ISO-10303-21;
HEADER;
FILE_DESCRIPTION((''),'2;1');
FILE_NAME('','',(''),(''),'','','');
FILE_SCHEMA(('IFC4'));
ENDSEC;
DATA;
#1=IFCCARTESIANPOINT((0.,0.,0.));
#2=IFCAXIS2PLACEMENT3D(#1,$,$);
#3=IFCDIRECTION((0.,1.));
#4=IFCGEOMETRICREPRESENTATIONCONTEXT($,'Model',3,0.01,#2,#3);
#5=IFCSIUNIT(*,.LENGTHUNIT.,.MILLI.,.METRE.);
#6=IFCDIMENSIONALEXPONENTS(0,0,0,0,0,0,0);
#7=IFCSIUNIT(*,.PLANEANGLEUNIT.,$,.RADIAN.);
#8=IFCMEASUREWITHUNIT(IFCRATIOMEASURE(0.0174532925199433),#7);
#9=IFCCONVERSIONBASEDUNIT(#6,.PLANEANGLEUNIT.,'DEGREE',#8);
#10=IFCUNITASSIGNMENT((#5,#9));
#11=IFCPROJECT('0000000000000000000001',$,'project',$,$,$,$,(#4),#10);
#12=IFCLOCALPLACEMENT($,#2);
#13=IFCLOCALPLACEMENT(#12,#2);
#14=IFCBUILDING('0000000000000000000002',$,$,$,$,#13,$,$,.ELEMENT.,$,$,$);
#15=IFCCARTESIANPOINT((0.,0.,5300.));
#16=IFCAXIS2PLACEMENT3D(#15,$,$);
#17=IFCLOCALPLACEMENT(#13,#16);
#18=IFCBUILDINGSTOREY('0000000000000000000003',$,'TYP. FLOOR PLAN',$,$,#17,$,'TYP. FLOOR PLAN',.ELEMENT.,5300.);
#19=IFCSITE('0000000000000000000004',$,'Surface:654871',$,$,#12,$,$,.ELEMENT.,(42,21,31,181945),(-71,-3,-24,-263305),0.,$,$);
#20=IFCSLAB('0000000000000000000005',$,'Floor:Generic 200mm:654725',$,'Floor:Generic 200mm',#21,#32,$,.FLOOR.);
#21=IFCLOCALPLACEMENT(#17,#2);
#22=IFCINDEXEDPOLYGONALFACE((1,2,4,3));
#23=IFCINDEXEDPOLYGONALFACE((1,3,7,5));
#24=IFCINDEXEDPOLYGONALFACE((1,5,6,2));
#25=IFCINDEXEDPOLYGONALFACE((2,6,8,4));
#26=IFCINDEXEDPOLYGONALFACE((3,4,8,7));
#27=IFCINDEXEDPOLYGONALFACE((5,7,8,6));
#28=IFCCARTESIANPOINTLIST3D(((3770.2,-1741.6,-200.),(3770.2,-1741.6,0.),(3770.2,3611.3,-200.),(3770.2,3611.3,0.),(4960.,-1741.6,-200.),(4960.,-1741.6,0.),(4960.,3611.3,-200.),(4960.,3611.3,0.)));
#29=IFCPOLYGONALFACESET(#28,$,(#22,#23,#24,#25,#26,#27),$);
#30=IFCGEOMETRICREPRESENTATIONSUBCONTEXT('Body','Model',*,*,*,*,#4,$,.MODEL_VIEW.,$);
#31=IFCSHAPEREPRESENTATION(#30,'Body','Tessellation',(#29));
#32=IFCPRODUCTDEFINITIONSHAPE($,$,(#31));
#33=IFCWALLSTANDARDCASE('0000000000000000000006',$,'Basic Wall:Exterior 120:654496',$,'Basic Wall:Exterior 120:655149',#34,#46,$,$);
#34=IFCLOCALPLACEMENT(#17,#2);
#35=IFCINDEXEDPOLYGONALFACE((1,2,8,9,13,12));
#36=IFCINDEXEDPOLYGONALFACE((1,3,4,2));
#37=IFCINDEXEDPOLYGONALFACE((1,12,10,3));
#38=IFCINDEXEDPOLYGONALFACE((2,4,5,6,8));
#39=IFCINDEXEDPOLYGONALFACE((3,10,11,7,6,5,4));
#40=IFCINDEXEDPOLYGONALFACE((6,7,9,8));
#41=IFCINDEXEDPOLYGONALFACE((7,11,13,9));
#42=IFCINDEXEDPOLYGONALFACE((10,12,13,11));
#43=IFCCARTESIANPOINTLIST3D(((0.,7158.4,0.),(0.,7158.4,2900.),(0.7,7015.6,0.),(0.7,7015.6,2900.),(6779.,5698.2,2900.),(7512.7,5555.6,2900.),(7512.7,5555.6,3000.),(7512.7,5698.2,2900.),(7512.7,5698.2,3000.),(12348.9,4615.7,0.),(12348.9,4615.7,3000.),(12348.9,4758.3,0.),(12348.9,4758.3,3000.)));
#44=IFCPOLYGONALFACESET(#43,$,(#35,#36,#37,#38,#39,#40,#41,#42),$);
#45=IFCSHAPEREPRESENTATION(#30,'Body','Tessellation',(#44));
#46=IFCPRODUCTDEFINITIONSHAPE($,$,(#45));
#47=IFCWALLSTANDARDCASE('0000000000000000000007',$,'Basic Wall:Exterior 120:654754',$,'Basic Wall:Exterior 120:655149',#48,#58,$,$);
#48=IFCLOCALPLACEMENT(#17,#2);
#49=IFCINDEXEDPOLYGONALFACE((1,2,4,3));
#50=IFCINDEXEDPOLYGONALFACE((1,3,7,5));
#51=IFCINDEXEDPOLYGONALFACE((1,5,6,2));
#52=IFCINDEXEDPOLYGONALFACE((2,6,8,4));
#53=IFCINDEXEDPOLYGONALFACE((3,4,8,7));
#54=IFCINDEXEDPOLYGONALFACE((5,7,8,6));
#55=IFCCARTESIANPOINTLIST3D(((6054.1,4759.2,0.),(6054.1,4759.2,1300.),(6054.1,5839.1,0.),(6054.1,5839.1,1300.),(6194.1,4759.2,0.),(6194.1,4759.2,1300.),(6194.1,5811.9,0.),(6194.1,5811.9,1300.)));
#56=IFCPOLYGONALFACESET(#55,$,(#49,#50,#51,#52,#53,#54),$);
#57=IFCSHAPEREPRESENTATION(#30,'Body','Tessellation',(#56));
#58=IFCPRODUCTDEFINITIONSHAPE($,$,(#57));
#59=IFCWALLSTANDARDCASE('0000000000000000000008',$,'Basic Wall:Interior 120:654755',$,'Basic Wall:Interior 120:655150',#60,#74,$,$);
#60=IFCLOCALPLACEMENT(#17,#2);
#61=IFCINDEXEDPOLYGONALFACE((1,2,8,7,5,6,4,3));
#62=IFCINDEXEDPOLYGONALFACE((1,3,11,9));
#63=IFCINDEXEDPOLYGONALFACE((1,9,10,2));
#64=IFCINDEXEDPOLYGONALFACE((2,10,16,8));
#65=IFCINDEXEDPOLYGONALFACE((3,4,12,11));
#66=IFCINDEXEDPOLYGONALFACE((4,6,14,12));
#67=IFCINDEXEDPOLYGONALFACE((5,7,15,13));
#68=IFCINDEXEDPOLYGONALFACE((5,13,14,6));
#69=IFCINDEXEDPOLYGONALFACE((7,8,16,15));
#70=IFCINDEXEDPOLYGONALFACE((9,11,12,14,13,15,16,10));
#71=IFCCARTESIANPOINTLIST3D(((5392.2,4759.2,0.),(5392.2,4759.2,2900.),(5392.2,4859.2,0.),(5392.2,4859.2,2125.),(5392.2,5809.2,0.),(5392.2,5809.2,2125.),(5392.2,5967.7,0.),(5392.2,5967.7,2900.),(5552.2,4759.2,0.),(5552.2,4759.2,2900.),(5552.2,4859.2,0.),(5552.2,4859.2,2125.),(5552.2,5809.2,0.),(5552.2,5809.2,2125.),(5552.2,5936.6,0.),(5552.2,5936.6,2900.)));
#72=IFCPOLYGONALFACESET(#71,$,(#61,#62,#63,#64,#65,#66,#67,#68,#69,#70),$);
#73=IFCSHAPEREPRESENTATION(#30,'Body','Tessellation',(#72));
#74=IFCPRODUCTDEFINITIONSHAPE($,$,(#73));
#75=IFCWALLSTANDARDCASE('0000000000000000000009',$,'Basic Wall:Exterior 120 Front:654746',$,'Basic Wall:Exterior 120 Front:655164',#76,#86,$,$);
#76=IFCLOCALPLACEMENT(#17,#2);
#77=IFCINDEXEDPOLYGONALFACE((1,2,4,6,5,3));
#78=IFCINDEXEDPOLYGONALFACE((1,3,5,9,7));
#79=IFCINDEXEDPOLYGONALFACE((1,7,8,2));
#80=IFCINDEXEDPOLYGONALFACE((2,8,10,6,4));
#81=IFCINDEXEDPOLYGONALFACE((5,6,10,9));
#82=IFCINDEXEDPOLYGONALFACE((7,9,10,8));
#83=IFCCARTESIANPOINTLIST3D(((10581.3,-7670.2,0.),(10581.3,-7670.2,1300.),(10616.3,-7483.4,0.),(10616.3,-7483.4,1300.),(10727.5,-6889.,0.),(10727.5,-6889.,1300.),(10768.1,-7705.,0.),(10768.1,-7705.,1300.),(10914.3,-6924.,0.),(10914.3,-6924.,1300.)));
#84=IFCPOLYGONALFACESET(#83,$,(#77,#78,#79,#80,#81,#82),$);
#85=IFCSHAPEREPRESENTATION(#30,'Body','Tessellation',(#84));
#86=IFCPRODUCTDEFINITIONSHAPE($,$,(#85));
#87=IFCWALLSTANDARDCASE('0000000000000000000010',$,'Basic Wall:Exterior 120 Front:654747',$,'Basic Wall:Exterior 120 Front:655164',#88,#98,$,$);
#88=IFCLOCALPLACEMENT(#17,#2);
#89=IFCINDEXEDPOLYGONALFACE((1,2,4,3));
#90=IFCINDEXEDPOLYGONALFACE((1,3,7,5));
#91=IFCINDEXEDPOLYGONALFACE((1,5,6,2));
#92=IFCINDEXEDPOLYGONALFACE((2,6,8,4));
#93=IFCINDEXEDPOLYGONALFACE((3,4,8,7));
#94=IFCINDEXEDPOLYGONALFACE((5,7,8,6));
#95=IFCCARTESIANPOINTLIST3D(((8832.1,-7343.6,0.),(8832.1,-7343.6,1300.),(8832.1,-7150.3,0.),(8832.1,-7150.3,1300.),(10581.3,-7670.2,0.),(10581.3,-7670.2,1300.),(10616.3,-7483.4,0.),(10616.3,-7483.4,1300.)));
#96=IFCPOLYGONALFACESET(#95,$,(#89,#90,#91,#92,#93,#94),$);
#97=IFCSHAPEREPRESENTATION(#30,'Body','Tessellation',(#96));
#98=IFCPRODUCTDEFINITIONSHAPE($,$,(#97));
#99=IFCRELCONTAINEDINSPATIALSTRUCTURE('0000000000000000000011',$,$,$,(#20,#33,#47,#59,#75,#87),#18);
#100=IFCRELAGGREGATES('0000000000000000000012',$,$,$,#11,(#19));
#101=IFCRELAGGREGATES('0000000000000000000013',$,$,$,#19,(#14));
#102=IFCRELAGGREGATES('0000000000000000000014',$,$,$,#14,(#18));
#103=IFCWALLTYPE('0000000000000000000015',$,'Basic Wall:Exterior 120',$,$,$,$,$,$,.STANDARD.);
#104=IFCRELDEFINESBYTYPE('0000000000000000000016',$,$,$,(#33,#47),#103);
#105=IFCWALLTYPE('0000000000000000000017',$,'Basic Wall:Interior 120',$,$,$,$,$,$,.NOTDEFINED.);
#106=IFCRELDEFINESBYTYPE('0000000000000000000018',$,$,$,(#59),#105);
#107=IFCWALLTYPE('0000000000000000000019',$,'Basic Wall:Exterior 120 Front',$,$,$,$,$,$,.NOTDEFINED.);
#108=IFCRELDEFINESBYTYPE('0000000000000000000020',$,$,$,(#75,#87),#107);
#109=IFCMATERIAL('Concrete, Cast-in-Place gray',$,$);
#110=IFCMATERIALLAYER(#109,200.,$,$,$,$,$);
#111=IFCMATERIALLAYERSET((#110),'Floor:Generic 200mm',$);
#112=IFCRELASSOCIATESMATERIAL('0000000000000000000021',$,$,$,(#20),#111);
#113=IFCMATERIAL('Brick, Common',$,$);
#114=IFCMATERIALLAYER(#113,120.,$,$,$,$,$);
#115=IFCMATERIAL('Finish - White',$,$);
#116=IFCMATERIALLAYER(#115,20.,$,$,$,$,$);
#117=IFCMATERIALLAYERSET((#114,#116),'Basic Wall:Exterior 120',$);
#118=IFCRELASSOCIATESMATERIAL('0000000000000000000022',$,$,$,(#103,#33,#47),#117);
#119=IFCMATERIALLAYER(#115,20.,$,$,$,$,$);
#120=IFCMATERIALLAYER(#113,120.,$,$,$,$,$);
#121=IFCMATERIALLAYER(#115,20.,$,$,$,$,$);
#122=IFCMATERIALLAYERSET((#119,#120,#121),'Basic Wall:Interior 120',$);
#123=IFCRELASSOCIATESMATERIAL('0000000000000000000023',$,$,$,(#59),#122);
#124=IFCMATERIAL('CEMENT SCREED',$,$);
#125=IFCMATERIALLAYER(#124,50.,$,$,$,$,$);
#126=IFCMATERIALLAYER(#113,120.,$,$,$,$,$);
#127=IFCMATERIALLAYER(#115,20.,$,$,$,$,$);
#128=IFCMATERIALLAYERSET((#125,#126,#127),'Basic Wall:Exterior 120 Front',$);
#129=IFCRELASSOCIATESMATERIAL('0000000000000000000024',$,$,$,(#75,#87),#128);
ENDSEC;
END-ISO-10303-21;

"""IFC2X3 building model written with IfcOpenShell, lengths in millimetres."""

from ifc_helpers import new_model, entity, si_unit, converted_unit, direction, frame, frame_2d, origin, place, context, subcontext, project, spatial, polyline, rectangle, outline, extrude, clip, bounded_halfspace, material, layer, layer_set, layer_usage, type_object, element, save


model = new_model("IFC2X3")

# Units and contexts
model_context = context("Model", 3, precision=0.01, world=origin(), true_north=direction((0.0, 1.0)))
body_context = subcontext(model_context, "Body", "Model", "MODEL_VIEW")
ifc_project = project(units=[si_unit("LENGTHUNIT", "METRE", prefix="MILLI"), converted_unit("PLANEANGLEUNIT", "DEGREE", entity("IfcRatioMeasure", 0.0174532925199433), si_unit("PLANEANGLEUNIT", "RADIAN"), dimensions=[0, 0, 0, 0, 0, 0, 0])], contexts=[model_context])

# Site, building, storey
site_placement = place(None, origin())
site = spatial("IfcSite", under=ifc_project, at=site_placement, Name="Surface:654871", CompositionType="ELEMENT", RefLatitude=(42, 21, 31, 181945), RefLongitude=(-71, -3, -24, -263305), RefElevation=0.0)
building_placement = place(site_placement, origin())
building = spatial("IfcBuilding", under=site, at=building_placement, CompositionType="ELEMENT")
storey_placement = place(building_placement, frame((0.0, 0.0, 5300.0)))
storey = spatial("IfcBuildingStorey", under=building, at=storey_placement, Name="TYP. FLOOR PLAN", LongName="TYP. FLOOR PLAN", CompositionType="ELEMENT", Elevation=5300.0)

# Slab
ifc_material_1 = material(Name="Concrete, Cast-in-Place gray")
ifc_layer_1 = layer(ifc_material_1, 200.0)
ifc_layer_set_1 = layer_set([ifc_layer_1], Name="Floor:Generic 200mm")
ifc_layer_usage_1 = layer_usage(ifc_layer_set_1, "AXIS3", "POSITIVE", 0.0)
slab_1_placement = place(storey_placement, origin())
element("IfcSlab", 1, at=slab_1_placement, inside=storey, material=ifc_layer_usage_1, Name="Floor:Generic 200mm:654725", ObjectType="Floor:Generic 200mm", PredefinedType="FLOOR", context=body_context, shape_type="SweptSolid", body=[
    extrude(rectangle(XDim=5353.0, YDim=1189.8, at=frame_2d((0.0, 0.0), x_axis=(1.0, 0.0))), frame((4365.1, 934.8, 0.0), z_axis=(0.0, 0.0, -1.0), x_axis=(0.0, 1.0, 0.0)), (0.0, 0.0, 1.0), 200.0),
])

# Walls
ifc_material_2 = material(Name="Brick, Common")
ifc_layer_2 = layer(ifc_material_2, 120.0)
ifc_material_3 = material(Name="Finish - White")
ifc_layer_3 = layer(ifc_material_3, 20.0)
ifc_layer_set_2 = layer_set([ifc_layer_2, ifc_layer_3], Name="Basic Wall:Exterior 120")
ifc_layer_usage_2 = layer_usage(ifc_layer_set_2, "AXIS2", "NEGATIVE", 70.0)
wall_type_1 = type_object("IfcWallType", Name="Basic Wall:Exterior 120", PredefinedType="STANDARD", material=ifc_layer_set_2)
wall_1_placement = place(storey_placement, frame((-13.4, 7089.6, 0.0), z_axis=(0.0, 0.0, 1.0), x_axis=(0.981632, -0.190785, 0.0)))
element("IfcWallStandardCase", 2, at=wall_1_placement, inside=storey, type_object=wall_type_1, material=ifc_layer_usage_2, Name="Basic Wall:Exterior 120:654496", ObjectType="Basic Wall:Exterior 120:655149", context=body_context, shape_type="Clipping", body=[
    clip(clip(extrude(outline(polyline([(12607.1, -70.0), (12579.9, 70.0), (0.0, 70.0), (28.0, -70.0), (170.7, -70.0), (5520.3, -70.0), (5683.3, -70.0), (6194.6, -70.0), (6337.2, -70.0), (10304.9, -70.0), (10467.9, -70.0), (12464.5, -70.0), (12607.1, -70.0)])), origin(), (0.0, 0.0, 1.0), 3000.0), bounded_halfspace(frame((7680.5, -70.0, 2900.0), z_axis=(0.0, 0.0, -1.0), x_axis=(1.0, 0.0, 0.0)), True, frame((7680.5, -70.0, 2900.0), z_axis=(0.0, 0.0, -1.0), x_axis=(1.0, 0.0, 0.0)), polyline([(0.0, 0.0), (-1997.2, 0.0), (-2160.2, 0.0), (-7509.8, 0.0), (-7652.6, 0.0), (-7680.5, -140.0), (-27.2, -140.0), (0.0, 0.0)]))), bounded_halfspace(frame((7653.3, 70.0, 2900.0), z_axis=(-0.981632, -0.190785, 0.0), x_axis=(0.0, 0.0, -1.0)), False, frame((7653.3, 70.0, 2900.0), z_axis=(-0.981632, -0.190785, 0.0), x_axis=(0.0, 0.0, -1.0)), polyline([(0.0, 0.0), (0.0, 142.6), (-100.0, 142.6), (-100.0, 0.0), (0.0, 0.0)]))),
])
ifc_layer_usage_3 = layer_usage(ifc_layer_set_2, "AXIS2", "NEGATIVE", 70.0)
wall_2_placement = place(storey_placement, frame((6124.1, 5839.1, 0.0), z_axis=(0.0, 0.0, 1.0), x_axis=(0.0, -1.0, 0.0)))
element("IfcWallStandardCase", 3, at=wall_2_placement, inside=storey, type_object=wall_type_1, material=ifc_layer_usage_3, Name="Basic Wall:Exterior 120:654754", ObjectType="Basic Wall:Exterior 120:655149", context=body_context, shape_type="SweptSolid", body=[
    extrude(outline(polyline([(1079.9, -70.0), (1079.9, 70.0), (27.2, 70.0), (0.0, -70.0), (1079.9, -70.0)])), origin(), (0.0, 0.0, 1.0), 1300.0),
])

# Shared definitions
ifc_layer_4 = layer(ifc_material_3, 20.0)
ifc_layer_5 = layer(ifc_material_2, 120.0)
ifc_layer_6 = layer(ifc_material_3, 20.0)
ifc_layer_set_3 = layer_set([ifc_layer_4, ifc_layer_5, ifc_layer_6], Name="Basic Wall:Interior 120")
wall_type_2 = type_object("IfcWallType", Name="Basic Wall:Interior 120", PredefinedType="NOTDEFINED")

# Wall, opening
ifc_layer_usage_4 = layer_usage(ifc_layer_set_3, "AXIS2", "POSITIVE", -80.0)
wall_3_placement = place(storey_placement, frame((5472.2, 5967.7, 0.0), z_axis=(0.0, 0.0, 1.0), x_axis=(0.0, -1.0, 0.0)))
wall_3 = element("IfcWallStandardCase", 4, at=wall_3_placement, inside=storey, type_object=wall_type_2, material=ifc_layer_usage_4, Name="Basic Wall:Interior 120:654755", ObjectType="Basic Wall:Interior 120:655150", context=body_context, shape_type="Clipping", body=[
    clip(extrude(outline(polyline([(0.0, -80.0), (1208.5, -80.0), (1208.5, 80.0), (31.1, 80.0), (0.0, -80.0)])), origin(), (0.0, 0.0, 1.0), 2900.0), bounded_halfspace(frame((0.0, -80.0, 2900.0), z_axis=(0.0, 0.0, -1.0), x_axis=(0.190785, 0.981632, 0.0)), True, frame((0.0, -80.0, 2900.0), z_axis=(0.0, 0.0, -1.0), x_axis=(0.190785, 0.981632, 0.0)), polyline([(0.0, 0.0), (163.0, 0.0), (387.6, 1155.8), (230.6, 1186.3), (0.0, 0.0)]))),
])
opening_1_placement = place(wall_3_placement, frame((1108.5, 80.0, 0.0)))
element("IfcOpeningElement", 5, at=opening_1_placement, cuts=wall_3, ObjectType="Opening", context=body_context, shape_type="SweptSolid", body=[
    extrude(rectangle(XDim=2125.0, YDim=950.0, at=frame_2d((1062.5, 475.0), x_axis=(1.0, 0.0))), frame((0.0, 0.0, 0.0), z_axis=(0.0, -1.0, 0.0), x_axis=(0.0, 0.0, 1.0)), (0.0, 0.0, 1.0), 160.0),
])

# Walls
ifc_material_4 = material(Name="CEMENT SCREED")
ifc_layer_7 = layer(ifc_material_4, 50.0)
ifc_layer_8 = layer(ifc_material_2, 120.0)
ifc_layer_9 = layer(ifc_material_3, 20.0)
ifc_layer_set_4 = layer_set([ifc_layer_7, ifc_layer_8, ifc_layer_9], Name="Basic Wall:Exterior 120 Front")
wall_type_3 = type_object("IfcWallType", Name="Basic Wall:Exterior 120 Front", PredefinedType="NOTDEFINED")
ifc_layer_usage_5 = layer_usage(ifc_layer_set_4, "AXIS2", "NEGATIVE", 95.0)
wall_4_placement = place(storey_placement, frame((10820.9, -6906.5, 0.0), z_axis=(0.0, 0.0, 1.0), x_axis=(-0.184019, -0.982923, 0.0)))
element("IfcWallStandardCase", 6, at=wall_4_placement, inside=storey, type_object=wall_type_3, material=ifc_layer_usage_5, Name="Basic Wall:Exterior 120 Front:654746", ObjectType="Basic Wall:Exterior 120 Front:655164", context=body_context, shape_type="SweptSolid", body=[
    extrude(outline(polyline([(794.7, -95.0), (794.6, 95.0), (0.0, 95.0), (0.0, -95.0), (604.7, -95.0), (794.7, -95.0)])), origin(), (0.0, 0.0, 1.0), 1300.0),
])
ifc_layer_usage_6 = layer_usage(ifc_layer_set_4, "AXIS2", "NEGATIVE", 95.0)
wall_5_placement = place(storey_placement, frame((10598.8, -7576.8, 0.0), z_axis=(0.0, 0.0, 1.0), x_axis=(-0.983013, 0.183538, 0.0)))
element("IfcWallStandardCase", 7, at=wall_5_placement, inside=storey, type_object=wall_type_3, material=ifc_layer_usage_6, Name="Basic Wall:Exterior 120 Front:654747", ObjectType="Basic Wall:Exterior 120 Front:655164", context=body_context, shape_type="SweptSolid", body=[
    extrude(outline(polyline([(1815.0, -95.0), (1779.5, 95.0), (0.1, 95.0), (0.0, -95.0), (1815.0, -95.0)])), origin(), (0.0, 0.0, 1.0), 1300.0),
])

save(model, "model.ifc")
